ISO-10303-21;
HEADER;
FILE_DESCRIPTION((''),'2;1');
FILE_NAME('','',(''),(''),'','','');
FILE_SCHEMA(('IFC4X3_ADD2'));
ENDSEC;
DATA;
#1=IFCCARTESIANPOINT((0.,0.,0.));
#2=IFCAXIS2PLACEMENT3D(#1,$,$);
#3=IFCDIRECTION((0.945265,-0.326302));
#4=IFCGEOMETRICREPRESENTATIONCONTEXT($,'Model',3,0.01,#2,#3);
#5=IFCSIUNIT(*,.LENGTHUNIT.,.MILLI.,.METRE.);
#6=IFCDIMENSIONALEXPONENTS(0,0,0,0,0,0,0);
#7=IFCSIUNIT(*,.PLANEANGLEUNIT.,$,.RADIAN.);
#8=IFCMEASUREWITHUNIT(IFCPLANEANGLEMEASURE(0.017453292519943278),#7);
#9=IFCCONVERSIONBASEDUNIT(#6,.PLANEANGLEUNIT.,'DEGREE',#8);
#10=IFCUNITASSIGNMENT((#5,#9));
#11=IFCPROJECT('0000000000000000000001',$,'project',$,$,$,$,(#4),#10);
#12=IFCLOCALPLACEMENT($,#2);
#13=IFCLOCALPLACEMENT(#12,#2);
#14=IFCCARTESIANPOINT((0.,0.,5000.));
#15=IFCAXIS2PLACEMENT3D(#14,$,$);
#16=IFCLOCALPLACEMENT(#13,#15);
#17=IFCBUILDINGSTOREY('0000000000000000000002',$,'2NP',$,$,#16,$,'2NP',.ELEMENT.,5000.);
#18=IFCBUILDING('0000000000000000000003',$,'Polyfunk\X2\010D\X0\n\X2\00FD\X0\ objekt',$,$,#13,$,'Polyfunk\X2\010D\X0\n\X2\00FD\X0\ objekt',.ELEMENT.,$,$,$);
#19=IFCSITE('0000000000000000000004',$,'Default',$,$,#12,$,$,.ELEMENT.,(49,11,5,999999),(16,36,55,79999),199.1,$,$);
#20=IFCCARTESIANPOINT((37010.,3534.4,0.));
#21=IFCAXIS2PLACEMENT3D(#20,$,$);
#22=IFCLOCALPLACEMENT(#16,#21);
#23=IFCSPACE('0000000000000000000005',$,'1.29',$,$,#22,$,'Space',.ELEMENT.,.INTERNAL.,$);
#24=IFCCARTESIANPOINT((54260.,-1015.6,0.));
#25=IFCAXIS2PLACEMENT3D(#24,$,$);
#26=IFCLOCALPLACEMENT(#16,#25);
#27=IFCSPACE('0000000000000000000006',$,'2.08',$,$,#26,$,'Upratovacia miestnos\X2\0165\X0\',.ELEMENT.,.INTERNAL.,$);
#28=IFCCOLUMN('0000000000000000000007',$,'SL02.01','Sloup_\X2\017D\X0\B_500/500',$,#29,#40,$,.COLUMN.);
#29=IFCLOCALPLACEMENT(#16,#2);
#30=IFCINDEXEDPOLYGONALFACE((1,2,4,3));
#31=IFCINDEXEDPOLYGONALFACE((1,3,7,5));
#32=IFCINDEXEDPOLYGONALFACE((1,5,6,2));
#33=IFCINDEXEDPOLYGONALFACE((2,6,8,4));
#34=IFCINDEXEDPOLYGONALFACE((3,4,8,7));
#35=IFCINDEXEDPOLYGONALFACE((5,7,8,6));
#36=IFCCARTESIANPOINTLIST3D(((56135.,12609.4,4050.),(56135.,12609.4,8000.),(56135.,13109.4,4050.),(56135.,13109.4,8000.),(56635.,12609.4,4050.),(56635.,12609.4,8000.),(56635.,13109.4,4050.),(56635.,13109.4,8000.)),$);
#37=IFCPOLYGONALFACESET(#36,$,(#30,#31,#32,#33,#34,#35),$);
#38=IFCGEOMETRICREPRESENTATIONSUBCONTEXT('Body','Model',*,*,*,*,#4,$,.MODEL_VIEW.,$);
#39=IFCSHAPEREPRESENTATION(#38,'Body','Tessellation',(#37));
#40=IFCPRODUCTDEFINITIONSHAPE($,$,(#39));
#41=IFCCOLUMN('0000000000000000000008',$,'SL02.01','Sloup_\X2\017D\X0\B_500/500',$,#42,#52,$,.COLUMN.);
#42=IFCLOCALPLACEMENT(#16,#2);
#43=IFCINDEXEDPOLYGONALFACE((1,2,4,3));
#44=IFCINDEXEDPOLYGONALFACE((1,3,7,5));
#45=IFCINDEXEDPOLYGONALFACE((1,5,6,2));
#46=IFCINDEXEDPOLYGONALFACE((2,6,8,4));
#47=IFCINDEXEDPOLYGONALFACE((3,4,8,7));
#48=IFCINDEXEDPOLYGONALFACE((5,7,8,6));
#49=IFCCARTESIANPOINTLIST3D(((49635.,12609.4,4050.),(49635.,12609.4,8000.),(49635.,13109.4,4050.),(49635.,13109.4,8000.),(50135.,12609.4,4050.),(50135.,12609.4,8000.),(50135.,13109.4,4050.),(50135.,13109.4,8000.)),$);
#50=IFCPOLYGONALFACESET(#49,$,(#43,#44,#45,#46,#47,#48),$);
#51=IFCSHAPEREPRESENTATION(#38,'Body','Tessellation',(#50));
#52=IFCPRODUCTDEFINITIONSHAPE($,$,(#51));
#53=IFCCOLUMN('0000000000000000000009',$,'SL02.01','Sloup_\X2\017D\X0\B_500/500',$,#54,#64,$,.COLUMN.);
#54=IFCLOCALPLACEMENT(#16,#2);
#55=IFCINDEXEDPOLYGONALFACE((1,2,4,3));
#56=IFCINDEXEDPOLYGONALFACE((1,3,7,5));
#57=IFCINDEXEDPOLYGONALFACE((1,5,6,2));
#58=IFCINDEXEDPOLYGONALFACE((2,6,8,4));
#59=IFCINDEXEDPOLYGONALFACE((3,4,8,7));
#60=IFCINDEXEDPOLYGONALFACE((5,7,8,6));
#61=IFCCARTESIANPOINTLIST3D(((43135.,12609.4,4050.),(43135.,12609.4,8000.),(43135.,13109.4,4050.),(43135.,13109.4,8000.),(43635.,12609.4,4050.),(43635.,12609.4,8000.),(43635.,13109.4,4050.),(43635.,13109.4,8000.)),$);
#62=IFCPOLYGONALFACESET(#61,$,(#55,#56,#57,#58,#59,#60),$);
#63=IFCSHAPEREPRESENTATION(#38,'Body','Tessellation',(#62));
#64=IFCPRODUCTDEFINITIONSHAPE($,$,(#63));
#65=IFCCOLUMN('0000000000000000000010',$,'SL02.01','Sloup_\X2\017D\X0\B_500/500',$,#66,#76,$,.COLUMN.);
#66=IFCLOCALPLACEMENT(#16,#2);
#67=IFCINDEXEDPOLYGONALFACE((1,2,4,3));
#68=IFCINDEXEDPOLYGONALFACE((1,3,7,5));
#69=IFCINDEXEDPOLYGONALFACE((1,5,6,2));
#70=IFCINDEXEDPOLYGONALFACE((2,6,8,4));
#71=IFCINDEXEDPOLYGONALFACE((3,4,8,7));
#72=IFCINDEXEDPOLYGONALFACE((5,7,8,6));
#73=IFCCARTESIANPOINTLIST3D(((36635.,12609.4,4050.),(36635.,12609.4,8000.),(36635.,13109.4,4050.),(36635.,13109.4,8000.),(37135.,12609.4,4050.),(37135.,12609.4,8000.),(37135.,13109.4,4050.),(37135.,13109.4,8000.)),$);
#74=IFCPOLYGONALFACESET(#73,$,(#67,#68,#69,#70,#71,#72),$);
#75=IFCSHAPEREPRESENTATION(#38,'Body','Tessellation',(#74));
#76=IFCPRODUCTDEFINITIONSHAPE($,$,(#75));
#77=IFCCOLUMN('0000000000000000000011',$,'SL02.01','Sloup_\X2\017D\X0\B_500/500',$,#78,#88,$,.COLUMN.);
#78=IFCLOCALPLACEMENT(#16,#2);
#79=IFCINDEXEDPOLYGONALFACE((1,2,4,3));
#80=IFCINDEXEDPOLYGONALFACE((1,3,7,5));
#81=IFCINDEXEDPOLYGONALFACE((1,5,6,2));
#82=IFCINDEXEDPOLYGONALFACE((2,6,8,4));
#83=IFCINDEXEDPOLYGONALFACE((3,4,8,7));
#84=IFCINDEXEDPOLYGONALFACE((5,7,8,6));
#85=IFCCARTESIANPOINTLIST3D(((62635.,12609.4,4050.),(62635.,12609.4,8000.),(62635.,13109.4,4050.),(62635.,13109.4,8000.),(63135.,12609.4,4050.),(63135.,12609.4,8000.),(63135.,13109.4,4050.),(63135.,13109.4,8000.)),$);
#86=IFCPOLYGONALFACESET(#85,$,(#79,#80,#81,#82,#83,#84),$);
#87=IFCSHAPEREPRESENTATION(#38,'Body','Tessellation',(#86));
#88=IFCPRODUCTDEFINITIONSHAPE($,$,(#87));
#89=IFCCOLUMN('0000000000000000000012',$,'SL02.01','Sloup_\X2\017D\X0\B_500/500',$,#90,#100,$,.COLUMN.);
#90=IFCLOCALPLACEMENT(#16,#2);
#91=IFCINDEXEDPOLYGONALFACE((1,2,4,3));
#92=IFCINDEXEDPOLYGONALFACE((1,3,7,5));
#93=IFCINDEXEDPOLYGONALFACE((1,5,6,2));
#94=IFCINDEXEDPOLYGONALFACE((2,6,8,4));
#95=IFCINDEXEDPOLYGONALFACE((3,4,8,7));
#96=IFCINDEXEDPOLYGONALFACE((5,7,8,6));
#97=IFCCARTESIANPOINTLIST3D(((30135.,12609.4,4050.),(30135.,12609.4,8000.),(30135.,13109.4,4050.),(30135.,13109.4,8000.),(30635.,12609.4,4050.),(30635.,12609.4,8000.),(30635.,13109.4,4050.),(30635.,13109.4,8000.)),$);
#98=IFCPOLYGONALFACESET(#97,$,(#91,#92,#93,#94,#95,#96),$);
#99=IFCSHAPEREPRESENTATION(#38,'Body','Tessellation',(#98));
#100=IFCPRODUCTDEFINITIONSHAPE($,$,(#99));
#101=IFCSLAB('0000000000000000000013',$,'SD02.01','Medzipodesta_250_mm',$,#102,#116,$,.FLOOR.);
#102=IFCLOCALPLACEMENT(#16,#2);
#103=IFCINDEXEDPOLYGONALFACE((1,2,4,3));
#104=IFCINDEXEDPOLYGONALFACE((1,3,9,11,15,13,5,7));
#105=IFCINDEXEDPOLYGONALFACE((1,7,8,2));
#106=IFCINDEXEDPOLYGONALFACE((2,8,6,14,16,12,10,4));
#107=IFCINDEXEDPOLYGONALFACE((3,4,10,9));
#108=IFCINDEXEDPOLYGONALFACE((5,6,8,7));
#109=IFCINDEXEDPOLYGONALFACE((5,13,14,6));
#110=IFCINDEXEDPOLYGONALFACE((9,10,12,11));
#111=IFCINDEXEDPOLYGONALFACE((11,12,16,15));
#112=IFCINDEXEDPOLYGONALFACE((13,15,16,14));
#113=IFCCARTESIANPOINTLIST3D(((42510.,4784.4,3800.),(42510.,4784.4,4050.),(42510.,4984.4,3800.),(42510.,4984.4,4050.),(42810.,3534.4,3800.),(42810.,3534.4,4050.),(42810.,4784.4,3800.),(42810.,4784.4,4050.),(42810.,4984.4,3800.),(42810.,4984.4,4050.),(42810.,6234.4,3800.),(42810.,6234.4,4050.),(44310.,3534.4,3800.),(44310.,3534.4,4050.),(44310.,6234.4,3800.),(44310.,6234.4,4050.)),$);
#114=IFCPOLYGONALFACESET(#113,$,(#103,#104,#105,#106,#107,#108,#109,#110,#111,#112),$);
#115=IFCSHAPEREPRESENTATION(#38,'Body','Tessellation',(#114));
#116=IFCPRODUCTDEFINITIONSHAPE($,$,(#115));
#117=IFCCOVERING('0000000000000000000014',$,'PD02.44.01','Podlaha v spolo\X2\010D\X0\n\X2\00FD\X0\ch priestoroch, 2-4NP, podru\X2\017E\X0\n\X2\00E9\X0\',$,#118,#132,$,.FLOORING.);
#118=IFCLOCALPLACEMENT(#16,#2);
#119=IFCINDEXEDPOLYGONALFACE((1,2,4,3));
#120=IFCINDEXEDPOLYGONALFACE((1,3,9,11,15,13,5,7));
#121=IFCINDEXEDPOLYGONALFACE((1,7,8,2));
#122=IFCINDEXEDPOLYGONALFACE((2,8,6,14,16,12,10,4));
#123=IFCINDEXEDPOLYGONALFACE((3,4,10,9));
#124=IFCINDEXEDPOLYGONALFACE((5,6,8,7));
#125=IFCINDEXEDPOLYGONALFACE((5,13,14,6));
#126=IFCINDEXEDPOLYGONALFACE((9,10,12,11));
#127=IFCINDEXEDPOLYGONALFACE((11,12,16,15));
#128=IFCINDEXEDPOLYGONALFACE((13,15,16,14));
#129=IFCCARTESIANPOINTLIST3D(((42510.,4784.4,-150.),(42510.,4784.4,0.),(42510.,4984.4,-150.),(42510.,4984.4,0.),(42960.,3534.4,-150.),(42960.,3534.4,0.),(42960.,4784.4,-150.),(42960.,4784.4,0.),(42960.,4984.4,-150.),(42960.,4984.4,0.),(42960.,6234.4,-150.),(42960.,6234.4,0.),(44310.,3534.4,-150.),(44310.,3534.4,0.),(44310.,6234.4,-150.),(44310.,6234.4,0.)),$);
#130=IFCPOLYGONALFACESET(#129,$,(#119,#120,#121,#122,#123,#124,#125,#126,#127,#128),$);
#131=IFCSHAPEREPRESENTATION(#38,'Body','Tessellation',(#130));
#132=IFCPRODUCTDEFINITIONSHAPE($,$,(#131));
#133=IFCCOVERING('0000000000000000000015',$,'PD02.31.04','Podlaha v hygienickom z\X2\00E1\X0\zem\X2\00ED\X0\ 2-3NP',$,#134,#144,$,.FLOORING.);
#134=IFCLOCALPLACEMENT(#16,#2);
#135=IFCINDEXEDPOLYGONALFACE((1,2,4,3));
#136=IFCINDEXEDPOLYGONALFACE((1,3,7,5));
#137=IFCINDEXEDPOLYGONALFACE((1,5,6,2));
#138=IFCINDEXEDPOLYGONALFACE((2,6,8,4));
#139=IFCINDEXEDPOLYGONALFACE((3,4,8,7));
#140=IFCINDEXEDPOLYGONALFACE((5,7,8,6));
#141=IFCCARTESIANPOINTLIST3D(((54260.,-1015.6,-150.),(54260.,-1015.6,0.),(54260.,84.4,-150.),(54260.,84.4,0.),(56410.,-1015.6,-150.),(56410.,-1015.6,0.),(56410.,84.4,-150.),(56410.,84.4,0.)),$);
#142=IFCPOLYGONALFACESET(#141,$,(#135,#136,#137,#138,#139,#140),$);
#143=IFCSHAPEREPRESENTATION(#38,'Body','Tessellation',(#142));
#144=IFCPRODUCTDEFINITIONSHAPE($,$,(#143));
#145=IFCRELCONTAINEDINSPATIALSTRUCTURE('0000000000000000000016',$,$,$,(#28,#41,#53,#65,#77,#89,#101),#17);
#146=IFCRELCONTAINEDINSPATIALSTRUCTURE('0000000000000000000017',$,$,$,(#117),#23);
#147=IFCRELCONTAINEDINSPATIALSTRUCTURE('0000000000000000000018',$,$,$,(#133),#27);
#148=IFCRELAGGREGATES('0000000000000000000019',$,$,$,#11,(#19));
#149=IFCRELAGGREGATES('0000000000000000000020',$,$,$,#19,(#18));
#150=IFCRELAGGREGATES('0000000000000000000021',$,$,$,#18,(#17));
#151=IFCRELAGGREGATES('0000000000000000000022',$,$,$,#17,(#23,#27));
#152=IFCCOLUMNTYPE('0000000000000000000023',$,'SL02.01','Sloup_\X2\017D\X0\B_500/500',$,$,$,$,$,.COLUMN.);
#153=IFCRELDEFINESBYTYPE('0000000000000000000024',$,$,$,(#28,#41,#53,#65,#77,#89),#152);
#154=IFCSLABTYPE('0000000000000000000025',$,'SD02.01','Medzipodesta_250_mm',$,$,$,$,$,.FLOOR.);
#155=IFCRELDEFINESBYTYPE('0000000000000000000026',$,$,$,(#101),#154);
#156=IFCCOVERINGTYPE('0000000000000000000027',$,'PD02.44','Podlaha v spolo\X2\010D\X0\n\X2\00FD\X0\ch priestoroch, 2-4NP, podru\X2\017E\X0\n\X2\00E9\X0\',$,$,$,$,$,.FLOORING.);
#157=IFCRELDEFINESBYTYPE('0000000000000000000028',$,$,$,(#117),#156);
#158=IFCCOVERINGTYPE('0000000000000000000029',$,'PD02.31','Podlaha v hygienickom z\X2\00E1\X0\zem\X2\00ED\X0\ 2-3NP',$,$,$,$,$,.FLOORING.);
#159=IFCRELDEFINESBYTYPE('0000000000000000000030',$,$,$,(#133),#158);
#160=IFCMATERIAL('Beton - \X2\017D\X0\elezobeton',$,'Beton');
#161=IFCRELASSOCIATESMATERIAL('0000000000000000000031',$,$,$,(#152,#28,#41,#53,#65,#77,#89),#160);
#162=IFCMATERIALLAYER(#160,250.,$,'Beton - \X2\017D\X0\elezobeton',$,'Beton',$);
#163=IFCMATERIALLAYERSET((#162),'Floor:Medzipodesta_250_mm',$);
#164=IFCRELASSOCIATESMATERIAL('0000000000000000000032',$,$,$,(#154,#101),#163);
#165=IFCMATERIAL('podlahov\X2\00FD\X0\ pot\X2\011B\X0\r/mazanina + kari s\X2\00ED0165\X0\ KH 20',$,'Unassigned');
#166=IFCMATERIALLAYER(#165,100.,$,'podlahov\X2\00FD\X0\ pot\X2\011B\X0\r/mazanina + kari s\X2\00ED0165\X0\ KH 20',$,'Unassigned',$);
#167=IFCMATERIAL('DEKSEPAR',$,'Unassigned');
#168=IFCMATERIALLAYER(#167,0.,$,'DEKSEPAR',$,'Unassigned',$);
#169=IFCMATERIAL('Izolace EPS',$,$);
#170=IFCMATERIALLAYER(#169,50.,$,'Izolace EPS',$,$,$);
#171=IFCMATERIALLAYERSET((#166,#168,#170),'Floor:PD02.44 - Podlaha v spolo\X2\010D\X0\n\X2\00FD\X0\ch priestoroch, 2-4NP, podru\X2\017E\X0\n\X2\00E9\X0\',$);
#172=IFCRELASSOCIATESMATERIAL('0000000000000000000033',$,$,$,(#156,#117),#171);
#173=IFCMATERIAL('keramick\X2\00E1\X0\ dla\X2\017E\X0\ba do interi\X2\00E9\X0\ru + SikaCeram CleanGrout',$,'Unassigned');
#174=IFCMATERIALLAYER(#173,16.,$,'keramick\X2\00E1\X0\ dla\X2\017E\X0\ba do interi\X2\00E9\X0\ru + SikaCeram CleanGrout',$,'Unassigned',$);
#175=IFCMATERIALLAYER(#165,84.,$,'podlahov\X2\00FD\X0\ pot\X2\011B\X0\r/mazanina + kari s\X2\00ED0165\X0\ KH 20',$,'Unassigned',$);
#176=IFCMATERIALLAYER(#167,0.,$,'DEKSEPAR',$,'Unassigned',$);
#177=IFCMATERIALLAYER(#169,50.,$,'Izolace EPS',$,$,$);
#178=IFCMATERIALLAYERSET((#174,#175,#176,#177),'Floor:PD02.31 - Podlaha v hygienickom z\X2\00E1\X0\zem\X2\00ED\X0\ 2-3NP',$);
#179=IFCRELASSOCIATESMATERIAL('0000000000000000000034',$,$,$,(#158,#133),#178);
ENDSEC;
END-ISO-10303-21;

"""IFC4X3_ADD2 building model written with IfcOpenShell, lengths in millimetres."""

from ifc_helpers import new_model, entity, si_unit, converted_unit, direction, frame, frame_2d, origin, origin_2d_with_axis, place, context, subcontext, project, spatial, polyline, rectangle, outline, extrude, source, transform, mapped, material, layer, layer_set, layer_usage, material_profile, profile_set, profile_usage, type_object, type_shapes, element, save


model = new_model("IFC4X3_ADD2")

# Units and contexts
model_context = context("Model", 3, precision=0.01, world=origin(), true_north=direction((0.945265, -0.326302)))
body_context = subcontext(model_context, "Body", "Model", "MODEL_VIEW")
ifc_project = project(units=[si_unit("LENGTHUNIT", "METRE", prefix="MILLI"), converted_unit("PLANEANGLEUNIT", "DEGREE", entity("IfcPlaneAngleMeasure", 0.017453292519943278), si_unit("PLANEANGLEUNIT", "RADIAN"), dimensions=[0, 0, 0, 0, 0, 0, 0])], contexts=[model_context])

# Site, building, storey
site_placement = place(None, origin())
site = spatial("IfcSite", under=ifc_project, at=site_placement, Name="Default", CompositionType="ELEMENT", RefLatitude=(49, 11, 5, 999999), RefLongitude=(16, 36, 55, 79999), RefElevation=199.1)
building_placement = place(site_placement, origin())
building = spatial("IfcBuilding", under=site, at=building_placement, Name="Polyfunkčný objekt", LongName="Polyfunkčný objekt", CompositionType="ELEMENT")
storey_placement = place(building_placement, frame((0.0, 0.0, 5000.0)))
storey = spatial("IfcBuildingStorey", under=building, at=storey_placement, Name="2NP", LongName="2NP", CompositionType="ELEMENT", Elevation=5000.0)

# Columns
ifc_material_1 = material(Name="Beton - Železobeton", Category="Beton")
ifc_material_profile_1 = material_profile(ifc_material_1, rectangle(XDim=500.0, YDim=500.0, at=frame_2d((0.0, 0.0), x_axis=(1.0, 0.0))), Name="Sloup_ŽB_500/500")
ifc_profile_set_1 = profile_set([ifc_material_profile_1], Name="Sloup_ŽB_500/500")
ifc_profile_usage_1 = profile_usage(ifc_profile_set_1)
column_type = type_object("IfcColumnType", Name="SL02.01", Description="Sloup_ŽB_500/500", PredefinedType="COLUMN", material=ifc_profile_set_1)
shared_shape_1 = source(origin(), body_context, "Body", "SweptSolid", [
    extrude(rectangle(XDim=500.0, YDim=500.0, at=frame_2d((0.0, 0.0), x_axis=(1.0, 0.0))), frame((56385.0, 12859.4, 9050.0)), (0.0, 0.0, 1.0), 3950.0),
])
column_1_placement = place(storey_placement, frame((0.0, 0.0, -5000.0)))
element("IfcColumn", 1, at=column_1_placement, inside=storey, type_object=column_type, material=ifc_profile_usage_1, Name="SL02.01", Description="Sloup_ŽB_500/500", PredefinedType="COLUMN", context=body_context, shape_type="MappedRepresentation", body=[
    mapped(shared_shape_1, transform((0.0, 0.0, 0.0), scale=1.0)),
])
shared_shape_2 = source(origin(), body_context, "Body", "SweptSolid", [
    extrude(rectangle(XDim=500.0, YDim=500.0, at=origin_2d_with_axis()), frame((49885.0, 12859.4, 9050.0)), (0.0, 0.0, 1.0), 3950.0),
])
column_2_placement = place(storey_placement, frame((0.0, 0.0, -5000.0)))
element("IfcColumn", 2, at=column_2_placement, inside=storey, type_object=column_type, material=ifc_profile_usage_1, Name="SL02.01", Description="Sloup_ŽB_500/500", PredefinedType="COLUMN", context=body_context, shape_type="MappedRepresentation", body=[
    mapped(shared_shape_2, transform((0.0, 0.0, 0.0), scale=1.0)),
])
shared_shape_3 = source(origin(), body_context, "Body", "SweptSolid", [
    extrude(rectangle(XDim=500.0, YDim=500.0, at=origin_2d_with_axis()), frame((43385.0, 12859.4, 9050.0)), (0.0, 0.0, 1.0), 3950.0),
])
column_3_placement = place(storey_placement, frame((0.0, 0.0, -5000.0)))
element("IfcColumn", 3, at=column_3_placement, inside=storey, type_object=column_type, material=ifc_profile_usage_1, Name="SL02.01", Description="Sloup_ŽB_500/500", PredefinedType="COLUMN", context=body_context, shape_type="MappedRepresentation", body=[
    mapped(shared_shape_3, transform((0.0, 0.0, 0.0), scale=1.0)),
])
shared_shape_4 = source(origin(), body_context, "Body", "SweptSolid", [
    extrude(rectangle(XDim=500.0, YDim=500.0, at=origin_2d_with_axis()), frame((36885.0, 12859.4, 9050.0)), (0.0, 0.0, 1.0), 3950.0),
])
column_4_placement = place(storey_placement, frame((0.0, 0.0, -5000.0)))
element("IfcColumn", 4, at=column_4_placement, inside=storey, type_object=column_type, material=ifc_profile_usage_1, Name="SL02.01", Description="Sloup_ŽB_500/500", PredefinedType="COLUMN", context=body_context, shape_type="MappedRepresentation", body=[
    mapped(shared_shape_4, transform((0.0, 0.0, 0.0), scale=1.0)),
])
shared_shape_5 = source(origin(), body_context, "Body", "SweptSolid", [
    extrude(rectangle(XDim=500.0, YDim=500.0, at=origin_2d_with_axis()), frame((62885.0, 12859.4, 9050.0), z_axis=(0.0, 0.0, 1.0), x_axis=(-1.0, 0.0, 0.0)), (0.0, 0.0, 1.0), 3950.0),
])
column_5_placement = place(storey_placement, frame((0.0, 0.0, -5000.0)))
element("IfcColumn", 5, at=column_5_placement, inside=storey, type_object=column_type, material=ifc_profile_usage_1, Name="SL02.01", Description="Sloup_ŽB_500/500", PredefinedType="COLUMN", context=body_context, shape_type="MappedRepresentation", body=[
    mapped(shared_shape_5, transform((0.0, 0.0, 0.0), scale=1.0)),
])
shared_shape_6 = source(origin(), body_context, "Body", "SweptSolid", [
    extrude(rectangle(XDim=500.0, YDim=500.0, at=origin_2d_with_axis()), frame((30385.0, 12859.4, 9050.0), z_axis=(0.0, 0.0, 1.0), x_axis=(-1.0, 0.0, 0.0)), (0.0, 0.0, 1.0), 3950.0),
])
type_shapes(column_type, [shared_shape_1, shared_shape_2, shared_shape_3, shared_shape_4, shared_shape_5, shared_shape_6])
column_6_placement = place(storey_placement, frame((0.0, 0.0, -5000.0)))
element("IfcColumn", 6, at=column_6_placement, inside=storey, type_object=column_type, material=ifc_profile_usage_1, Name="SL02.01", Description="Sloup_ŽB_500/500", PredefinedType="COLUMN", context=body_context, shape_type="MappedRepresentation", body=[
    mapped(shared_shape_6, transform((0.0, 0.0, 0.0), scale=1.0)),
])

# Slab
ifc_layer_1 = layer(ifc_material_1, 250.0, Name="Beton - Železobeton", Category="Beton")
ifc_layer_set_1 = layer_set([ifc_layer_1], Name="Floor:Medzipodesta_250_mm")
ifc_layer_usage_1 = layer_usage(ifc_layer_set_1, "AXIS3", "POSITIVE", 0.0)
slab_type_1 = type_object("IfcSlabType", Name="SD02.01", Description="Medzipodesta_250_mm", PredefinedType="FLOOR", material=ifc_layer_set_1)
slab_1_placement = place(storey_placement, origin())
element("IfcSlab", 7, at=slab_1_placement, inside=storey, type_object=slab_type_1, material=ifc_layer_usage_1, Name="SD02.01", Description="Medzipodesta_250_mm", PredefinedType="FLOOR", context=body_context, shape_type="SweptSolid", body=[
    extrude(outline(polyline([(-100.0, -600.0), (100.0, -600.0), (100.0, -300.0), (1350.0, -300.0), (1350.0, 1200.0), (-1350.0, 1200.0), (-1350.0, -300.0), (-100.0, -300.0), (-100.0, -600.0)])), frame((43110.0, 4884.4, 4050.0), z_axis=(0.0, 0.0, -1.0), x_axis=(0.0, 1.0, 0.0)), (0.0, 0.0, 1.0), 250.0),
])

# Shared definitions
space_1_placement = place(storey_placement, frame((37010.0, 3534.4, 0.0)))
space_1 = spatial("IfcSpace", under=storey, at=space_1_placement, Name="1.29", LongName="Space", CompositionType="ELEMENT", PredefinedType="INTERNAL")

# Covering
ifc_material_2 = material(Name="podlahový potěr/mazanina + kari síť KH 20", Category="Unassigned")
ifc_layer_2 = layer(ifc_material_2, 100.0, Name="podlahový potěr/mazanina + kari síť KH 20", Category="Unassigned")
ifc_material_3 = material(Name="DEKSEPAR", Category="Unassigned")
ifc_layer_3 = layer(ifc_material_3, 0.0, Name="DEKSEPAR", Category="Unassigned")
ifc_material_4 = material(Name="Izolace EPS")
ifc_layer_4 = layer(ifc_material_4, 50.0, Name="Izolace EPS")
ifc_layer_set_2 = layer_set([ifc_layer_2, ifc_layer_3, ifc_layer_4], Name="Floor:PD02.44 - Podlaha v spoločných priestoroch, 2-4NP, podružné")
ifc_layer_usage_2 = layer_usage(ifc_layer_set_2, "AXIS3", "POSITIVE", 0.0)
covering_type_1 = type_object("IfcCoveringType", Name="PD02.44", Description="Podlaha v spoločných priestoroch, 2-4NP, podružné", PredefinedType="FLOORING", material=ifc_layer_set_2)
covering_1_placement = place(storey_placement, origin())
element("IfcCovering", 8, at=covering_1_placement, inside=space_1, type_object=covering_type_1, material=ifc_layer_usage_2, Name="PD02.44.01", Description="Podlaha v spoločných priestoroch, 2-4NP, podružné", PredefinedType="FLOORING", context=body_context, shape_type="SweptSolid", body=[
    extrude(outline(polyline([(-100.0, -675.0), (100.0, -675.0), (100.0, -225.0), (1350.0, -225.0), (1350.0, 1125.0), (-1350.0, 1125.0), (-1350.0, -225.0), (-100.0, -225.0), (-100.0, -675.0)])), frame((43185.0, 4884.4, 0.0), z_axis=(0.0, 0.0, -1.0), x_axis=(0.0, 1.0, 0.0)), (0.0, 0.0, 1.0), 150.0),
])

# Shared definitions
ifc_material_5 = material(Name="keramická dlažba do interiéru + SikaCeram CleanGrout", Category="Unassigned")
ifc_layer_5 = layer(ifc_material_5, 16.0, Name="keramická dlažba do interiéru + SikaCeram CleanGrout", Category="Unassigned")
ifc_layer_6 = layer(ifc_material_2, 84.0, Name="podlahový potěr/mazanina + kari síť KH 20", Category="Unassigned")
ifc_layer_7 = layer(ifc_material_3, 0.0, Name="DEKSEPAR", Category="Unassigned")
ifc_layer_8 = layer(ifc_material_4, 50.0, Name="Izolace EPS")
ifc_layer_set_3 = layer_set([ifc_layer_5, ifc_layer_6, ifc_layer_7, ifc_layer_8], Name="Floor:PD02.31 - Podlaha v hygienickom zázemí 2-3NP")
covering_type_2 = type_object("IfcCoveringType", Name="PD02.31", Description="Podlaha v hygienickom zázemí 2-3NP", PredefinedType="FLOORING", material=ifc_layer_set_3)

# Shared definitions
space_2_placement = place(storey_placement, frame((54260.0, -1015.6, 0.0)))
space_2 = spatial("IfcSpace", under=storey, at=space_2_placement, Name="2.08", LongName="Upratovacia miestnosť", CompositionType="ELEMENT", PredefinedType="INTERNAL")

# Covering
ifc_layer_usage_3 = layer_usage(ifc_layer_set_3, "AXIS3", "POSITIVE", 0.0)
covering_2_placement = place(storey_placement, origin())
element("IfcCovering", 9, at=covering_2_placement, inside=space_2, type_object=covering_type_2, material=ifc_layer_usage_3, Name="PD02.31.04", Description="Podlaha v hygienickom zázemí 2-3NP", PredefinedType="FLOORING", context=body_context, shape_type="SweptSolid", body=[
    extrude(rectangle(XDim=1100.0, YDim=2150.0, at=frame_2d((0.0, 0.0), x_axis=(1.0, 0.0))), frame((55335.0, -465.6, 0.0), z_axis=(0.0, 0.0, -1.0), x_axis=(0.0, 1.0, 0.0)), (0.0, 0.0, 1.0), 150.0),
])

save(model, "model.ifc")
